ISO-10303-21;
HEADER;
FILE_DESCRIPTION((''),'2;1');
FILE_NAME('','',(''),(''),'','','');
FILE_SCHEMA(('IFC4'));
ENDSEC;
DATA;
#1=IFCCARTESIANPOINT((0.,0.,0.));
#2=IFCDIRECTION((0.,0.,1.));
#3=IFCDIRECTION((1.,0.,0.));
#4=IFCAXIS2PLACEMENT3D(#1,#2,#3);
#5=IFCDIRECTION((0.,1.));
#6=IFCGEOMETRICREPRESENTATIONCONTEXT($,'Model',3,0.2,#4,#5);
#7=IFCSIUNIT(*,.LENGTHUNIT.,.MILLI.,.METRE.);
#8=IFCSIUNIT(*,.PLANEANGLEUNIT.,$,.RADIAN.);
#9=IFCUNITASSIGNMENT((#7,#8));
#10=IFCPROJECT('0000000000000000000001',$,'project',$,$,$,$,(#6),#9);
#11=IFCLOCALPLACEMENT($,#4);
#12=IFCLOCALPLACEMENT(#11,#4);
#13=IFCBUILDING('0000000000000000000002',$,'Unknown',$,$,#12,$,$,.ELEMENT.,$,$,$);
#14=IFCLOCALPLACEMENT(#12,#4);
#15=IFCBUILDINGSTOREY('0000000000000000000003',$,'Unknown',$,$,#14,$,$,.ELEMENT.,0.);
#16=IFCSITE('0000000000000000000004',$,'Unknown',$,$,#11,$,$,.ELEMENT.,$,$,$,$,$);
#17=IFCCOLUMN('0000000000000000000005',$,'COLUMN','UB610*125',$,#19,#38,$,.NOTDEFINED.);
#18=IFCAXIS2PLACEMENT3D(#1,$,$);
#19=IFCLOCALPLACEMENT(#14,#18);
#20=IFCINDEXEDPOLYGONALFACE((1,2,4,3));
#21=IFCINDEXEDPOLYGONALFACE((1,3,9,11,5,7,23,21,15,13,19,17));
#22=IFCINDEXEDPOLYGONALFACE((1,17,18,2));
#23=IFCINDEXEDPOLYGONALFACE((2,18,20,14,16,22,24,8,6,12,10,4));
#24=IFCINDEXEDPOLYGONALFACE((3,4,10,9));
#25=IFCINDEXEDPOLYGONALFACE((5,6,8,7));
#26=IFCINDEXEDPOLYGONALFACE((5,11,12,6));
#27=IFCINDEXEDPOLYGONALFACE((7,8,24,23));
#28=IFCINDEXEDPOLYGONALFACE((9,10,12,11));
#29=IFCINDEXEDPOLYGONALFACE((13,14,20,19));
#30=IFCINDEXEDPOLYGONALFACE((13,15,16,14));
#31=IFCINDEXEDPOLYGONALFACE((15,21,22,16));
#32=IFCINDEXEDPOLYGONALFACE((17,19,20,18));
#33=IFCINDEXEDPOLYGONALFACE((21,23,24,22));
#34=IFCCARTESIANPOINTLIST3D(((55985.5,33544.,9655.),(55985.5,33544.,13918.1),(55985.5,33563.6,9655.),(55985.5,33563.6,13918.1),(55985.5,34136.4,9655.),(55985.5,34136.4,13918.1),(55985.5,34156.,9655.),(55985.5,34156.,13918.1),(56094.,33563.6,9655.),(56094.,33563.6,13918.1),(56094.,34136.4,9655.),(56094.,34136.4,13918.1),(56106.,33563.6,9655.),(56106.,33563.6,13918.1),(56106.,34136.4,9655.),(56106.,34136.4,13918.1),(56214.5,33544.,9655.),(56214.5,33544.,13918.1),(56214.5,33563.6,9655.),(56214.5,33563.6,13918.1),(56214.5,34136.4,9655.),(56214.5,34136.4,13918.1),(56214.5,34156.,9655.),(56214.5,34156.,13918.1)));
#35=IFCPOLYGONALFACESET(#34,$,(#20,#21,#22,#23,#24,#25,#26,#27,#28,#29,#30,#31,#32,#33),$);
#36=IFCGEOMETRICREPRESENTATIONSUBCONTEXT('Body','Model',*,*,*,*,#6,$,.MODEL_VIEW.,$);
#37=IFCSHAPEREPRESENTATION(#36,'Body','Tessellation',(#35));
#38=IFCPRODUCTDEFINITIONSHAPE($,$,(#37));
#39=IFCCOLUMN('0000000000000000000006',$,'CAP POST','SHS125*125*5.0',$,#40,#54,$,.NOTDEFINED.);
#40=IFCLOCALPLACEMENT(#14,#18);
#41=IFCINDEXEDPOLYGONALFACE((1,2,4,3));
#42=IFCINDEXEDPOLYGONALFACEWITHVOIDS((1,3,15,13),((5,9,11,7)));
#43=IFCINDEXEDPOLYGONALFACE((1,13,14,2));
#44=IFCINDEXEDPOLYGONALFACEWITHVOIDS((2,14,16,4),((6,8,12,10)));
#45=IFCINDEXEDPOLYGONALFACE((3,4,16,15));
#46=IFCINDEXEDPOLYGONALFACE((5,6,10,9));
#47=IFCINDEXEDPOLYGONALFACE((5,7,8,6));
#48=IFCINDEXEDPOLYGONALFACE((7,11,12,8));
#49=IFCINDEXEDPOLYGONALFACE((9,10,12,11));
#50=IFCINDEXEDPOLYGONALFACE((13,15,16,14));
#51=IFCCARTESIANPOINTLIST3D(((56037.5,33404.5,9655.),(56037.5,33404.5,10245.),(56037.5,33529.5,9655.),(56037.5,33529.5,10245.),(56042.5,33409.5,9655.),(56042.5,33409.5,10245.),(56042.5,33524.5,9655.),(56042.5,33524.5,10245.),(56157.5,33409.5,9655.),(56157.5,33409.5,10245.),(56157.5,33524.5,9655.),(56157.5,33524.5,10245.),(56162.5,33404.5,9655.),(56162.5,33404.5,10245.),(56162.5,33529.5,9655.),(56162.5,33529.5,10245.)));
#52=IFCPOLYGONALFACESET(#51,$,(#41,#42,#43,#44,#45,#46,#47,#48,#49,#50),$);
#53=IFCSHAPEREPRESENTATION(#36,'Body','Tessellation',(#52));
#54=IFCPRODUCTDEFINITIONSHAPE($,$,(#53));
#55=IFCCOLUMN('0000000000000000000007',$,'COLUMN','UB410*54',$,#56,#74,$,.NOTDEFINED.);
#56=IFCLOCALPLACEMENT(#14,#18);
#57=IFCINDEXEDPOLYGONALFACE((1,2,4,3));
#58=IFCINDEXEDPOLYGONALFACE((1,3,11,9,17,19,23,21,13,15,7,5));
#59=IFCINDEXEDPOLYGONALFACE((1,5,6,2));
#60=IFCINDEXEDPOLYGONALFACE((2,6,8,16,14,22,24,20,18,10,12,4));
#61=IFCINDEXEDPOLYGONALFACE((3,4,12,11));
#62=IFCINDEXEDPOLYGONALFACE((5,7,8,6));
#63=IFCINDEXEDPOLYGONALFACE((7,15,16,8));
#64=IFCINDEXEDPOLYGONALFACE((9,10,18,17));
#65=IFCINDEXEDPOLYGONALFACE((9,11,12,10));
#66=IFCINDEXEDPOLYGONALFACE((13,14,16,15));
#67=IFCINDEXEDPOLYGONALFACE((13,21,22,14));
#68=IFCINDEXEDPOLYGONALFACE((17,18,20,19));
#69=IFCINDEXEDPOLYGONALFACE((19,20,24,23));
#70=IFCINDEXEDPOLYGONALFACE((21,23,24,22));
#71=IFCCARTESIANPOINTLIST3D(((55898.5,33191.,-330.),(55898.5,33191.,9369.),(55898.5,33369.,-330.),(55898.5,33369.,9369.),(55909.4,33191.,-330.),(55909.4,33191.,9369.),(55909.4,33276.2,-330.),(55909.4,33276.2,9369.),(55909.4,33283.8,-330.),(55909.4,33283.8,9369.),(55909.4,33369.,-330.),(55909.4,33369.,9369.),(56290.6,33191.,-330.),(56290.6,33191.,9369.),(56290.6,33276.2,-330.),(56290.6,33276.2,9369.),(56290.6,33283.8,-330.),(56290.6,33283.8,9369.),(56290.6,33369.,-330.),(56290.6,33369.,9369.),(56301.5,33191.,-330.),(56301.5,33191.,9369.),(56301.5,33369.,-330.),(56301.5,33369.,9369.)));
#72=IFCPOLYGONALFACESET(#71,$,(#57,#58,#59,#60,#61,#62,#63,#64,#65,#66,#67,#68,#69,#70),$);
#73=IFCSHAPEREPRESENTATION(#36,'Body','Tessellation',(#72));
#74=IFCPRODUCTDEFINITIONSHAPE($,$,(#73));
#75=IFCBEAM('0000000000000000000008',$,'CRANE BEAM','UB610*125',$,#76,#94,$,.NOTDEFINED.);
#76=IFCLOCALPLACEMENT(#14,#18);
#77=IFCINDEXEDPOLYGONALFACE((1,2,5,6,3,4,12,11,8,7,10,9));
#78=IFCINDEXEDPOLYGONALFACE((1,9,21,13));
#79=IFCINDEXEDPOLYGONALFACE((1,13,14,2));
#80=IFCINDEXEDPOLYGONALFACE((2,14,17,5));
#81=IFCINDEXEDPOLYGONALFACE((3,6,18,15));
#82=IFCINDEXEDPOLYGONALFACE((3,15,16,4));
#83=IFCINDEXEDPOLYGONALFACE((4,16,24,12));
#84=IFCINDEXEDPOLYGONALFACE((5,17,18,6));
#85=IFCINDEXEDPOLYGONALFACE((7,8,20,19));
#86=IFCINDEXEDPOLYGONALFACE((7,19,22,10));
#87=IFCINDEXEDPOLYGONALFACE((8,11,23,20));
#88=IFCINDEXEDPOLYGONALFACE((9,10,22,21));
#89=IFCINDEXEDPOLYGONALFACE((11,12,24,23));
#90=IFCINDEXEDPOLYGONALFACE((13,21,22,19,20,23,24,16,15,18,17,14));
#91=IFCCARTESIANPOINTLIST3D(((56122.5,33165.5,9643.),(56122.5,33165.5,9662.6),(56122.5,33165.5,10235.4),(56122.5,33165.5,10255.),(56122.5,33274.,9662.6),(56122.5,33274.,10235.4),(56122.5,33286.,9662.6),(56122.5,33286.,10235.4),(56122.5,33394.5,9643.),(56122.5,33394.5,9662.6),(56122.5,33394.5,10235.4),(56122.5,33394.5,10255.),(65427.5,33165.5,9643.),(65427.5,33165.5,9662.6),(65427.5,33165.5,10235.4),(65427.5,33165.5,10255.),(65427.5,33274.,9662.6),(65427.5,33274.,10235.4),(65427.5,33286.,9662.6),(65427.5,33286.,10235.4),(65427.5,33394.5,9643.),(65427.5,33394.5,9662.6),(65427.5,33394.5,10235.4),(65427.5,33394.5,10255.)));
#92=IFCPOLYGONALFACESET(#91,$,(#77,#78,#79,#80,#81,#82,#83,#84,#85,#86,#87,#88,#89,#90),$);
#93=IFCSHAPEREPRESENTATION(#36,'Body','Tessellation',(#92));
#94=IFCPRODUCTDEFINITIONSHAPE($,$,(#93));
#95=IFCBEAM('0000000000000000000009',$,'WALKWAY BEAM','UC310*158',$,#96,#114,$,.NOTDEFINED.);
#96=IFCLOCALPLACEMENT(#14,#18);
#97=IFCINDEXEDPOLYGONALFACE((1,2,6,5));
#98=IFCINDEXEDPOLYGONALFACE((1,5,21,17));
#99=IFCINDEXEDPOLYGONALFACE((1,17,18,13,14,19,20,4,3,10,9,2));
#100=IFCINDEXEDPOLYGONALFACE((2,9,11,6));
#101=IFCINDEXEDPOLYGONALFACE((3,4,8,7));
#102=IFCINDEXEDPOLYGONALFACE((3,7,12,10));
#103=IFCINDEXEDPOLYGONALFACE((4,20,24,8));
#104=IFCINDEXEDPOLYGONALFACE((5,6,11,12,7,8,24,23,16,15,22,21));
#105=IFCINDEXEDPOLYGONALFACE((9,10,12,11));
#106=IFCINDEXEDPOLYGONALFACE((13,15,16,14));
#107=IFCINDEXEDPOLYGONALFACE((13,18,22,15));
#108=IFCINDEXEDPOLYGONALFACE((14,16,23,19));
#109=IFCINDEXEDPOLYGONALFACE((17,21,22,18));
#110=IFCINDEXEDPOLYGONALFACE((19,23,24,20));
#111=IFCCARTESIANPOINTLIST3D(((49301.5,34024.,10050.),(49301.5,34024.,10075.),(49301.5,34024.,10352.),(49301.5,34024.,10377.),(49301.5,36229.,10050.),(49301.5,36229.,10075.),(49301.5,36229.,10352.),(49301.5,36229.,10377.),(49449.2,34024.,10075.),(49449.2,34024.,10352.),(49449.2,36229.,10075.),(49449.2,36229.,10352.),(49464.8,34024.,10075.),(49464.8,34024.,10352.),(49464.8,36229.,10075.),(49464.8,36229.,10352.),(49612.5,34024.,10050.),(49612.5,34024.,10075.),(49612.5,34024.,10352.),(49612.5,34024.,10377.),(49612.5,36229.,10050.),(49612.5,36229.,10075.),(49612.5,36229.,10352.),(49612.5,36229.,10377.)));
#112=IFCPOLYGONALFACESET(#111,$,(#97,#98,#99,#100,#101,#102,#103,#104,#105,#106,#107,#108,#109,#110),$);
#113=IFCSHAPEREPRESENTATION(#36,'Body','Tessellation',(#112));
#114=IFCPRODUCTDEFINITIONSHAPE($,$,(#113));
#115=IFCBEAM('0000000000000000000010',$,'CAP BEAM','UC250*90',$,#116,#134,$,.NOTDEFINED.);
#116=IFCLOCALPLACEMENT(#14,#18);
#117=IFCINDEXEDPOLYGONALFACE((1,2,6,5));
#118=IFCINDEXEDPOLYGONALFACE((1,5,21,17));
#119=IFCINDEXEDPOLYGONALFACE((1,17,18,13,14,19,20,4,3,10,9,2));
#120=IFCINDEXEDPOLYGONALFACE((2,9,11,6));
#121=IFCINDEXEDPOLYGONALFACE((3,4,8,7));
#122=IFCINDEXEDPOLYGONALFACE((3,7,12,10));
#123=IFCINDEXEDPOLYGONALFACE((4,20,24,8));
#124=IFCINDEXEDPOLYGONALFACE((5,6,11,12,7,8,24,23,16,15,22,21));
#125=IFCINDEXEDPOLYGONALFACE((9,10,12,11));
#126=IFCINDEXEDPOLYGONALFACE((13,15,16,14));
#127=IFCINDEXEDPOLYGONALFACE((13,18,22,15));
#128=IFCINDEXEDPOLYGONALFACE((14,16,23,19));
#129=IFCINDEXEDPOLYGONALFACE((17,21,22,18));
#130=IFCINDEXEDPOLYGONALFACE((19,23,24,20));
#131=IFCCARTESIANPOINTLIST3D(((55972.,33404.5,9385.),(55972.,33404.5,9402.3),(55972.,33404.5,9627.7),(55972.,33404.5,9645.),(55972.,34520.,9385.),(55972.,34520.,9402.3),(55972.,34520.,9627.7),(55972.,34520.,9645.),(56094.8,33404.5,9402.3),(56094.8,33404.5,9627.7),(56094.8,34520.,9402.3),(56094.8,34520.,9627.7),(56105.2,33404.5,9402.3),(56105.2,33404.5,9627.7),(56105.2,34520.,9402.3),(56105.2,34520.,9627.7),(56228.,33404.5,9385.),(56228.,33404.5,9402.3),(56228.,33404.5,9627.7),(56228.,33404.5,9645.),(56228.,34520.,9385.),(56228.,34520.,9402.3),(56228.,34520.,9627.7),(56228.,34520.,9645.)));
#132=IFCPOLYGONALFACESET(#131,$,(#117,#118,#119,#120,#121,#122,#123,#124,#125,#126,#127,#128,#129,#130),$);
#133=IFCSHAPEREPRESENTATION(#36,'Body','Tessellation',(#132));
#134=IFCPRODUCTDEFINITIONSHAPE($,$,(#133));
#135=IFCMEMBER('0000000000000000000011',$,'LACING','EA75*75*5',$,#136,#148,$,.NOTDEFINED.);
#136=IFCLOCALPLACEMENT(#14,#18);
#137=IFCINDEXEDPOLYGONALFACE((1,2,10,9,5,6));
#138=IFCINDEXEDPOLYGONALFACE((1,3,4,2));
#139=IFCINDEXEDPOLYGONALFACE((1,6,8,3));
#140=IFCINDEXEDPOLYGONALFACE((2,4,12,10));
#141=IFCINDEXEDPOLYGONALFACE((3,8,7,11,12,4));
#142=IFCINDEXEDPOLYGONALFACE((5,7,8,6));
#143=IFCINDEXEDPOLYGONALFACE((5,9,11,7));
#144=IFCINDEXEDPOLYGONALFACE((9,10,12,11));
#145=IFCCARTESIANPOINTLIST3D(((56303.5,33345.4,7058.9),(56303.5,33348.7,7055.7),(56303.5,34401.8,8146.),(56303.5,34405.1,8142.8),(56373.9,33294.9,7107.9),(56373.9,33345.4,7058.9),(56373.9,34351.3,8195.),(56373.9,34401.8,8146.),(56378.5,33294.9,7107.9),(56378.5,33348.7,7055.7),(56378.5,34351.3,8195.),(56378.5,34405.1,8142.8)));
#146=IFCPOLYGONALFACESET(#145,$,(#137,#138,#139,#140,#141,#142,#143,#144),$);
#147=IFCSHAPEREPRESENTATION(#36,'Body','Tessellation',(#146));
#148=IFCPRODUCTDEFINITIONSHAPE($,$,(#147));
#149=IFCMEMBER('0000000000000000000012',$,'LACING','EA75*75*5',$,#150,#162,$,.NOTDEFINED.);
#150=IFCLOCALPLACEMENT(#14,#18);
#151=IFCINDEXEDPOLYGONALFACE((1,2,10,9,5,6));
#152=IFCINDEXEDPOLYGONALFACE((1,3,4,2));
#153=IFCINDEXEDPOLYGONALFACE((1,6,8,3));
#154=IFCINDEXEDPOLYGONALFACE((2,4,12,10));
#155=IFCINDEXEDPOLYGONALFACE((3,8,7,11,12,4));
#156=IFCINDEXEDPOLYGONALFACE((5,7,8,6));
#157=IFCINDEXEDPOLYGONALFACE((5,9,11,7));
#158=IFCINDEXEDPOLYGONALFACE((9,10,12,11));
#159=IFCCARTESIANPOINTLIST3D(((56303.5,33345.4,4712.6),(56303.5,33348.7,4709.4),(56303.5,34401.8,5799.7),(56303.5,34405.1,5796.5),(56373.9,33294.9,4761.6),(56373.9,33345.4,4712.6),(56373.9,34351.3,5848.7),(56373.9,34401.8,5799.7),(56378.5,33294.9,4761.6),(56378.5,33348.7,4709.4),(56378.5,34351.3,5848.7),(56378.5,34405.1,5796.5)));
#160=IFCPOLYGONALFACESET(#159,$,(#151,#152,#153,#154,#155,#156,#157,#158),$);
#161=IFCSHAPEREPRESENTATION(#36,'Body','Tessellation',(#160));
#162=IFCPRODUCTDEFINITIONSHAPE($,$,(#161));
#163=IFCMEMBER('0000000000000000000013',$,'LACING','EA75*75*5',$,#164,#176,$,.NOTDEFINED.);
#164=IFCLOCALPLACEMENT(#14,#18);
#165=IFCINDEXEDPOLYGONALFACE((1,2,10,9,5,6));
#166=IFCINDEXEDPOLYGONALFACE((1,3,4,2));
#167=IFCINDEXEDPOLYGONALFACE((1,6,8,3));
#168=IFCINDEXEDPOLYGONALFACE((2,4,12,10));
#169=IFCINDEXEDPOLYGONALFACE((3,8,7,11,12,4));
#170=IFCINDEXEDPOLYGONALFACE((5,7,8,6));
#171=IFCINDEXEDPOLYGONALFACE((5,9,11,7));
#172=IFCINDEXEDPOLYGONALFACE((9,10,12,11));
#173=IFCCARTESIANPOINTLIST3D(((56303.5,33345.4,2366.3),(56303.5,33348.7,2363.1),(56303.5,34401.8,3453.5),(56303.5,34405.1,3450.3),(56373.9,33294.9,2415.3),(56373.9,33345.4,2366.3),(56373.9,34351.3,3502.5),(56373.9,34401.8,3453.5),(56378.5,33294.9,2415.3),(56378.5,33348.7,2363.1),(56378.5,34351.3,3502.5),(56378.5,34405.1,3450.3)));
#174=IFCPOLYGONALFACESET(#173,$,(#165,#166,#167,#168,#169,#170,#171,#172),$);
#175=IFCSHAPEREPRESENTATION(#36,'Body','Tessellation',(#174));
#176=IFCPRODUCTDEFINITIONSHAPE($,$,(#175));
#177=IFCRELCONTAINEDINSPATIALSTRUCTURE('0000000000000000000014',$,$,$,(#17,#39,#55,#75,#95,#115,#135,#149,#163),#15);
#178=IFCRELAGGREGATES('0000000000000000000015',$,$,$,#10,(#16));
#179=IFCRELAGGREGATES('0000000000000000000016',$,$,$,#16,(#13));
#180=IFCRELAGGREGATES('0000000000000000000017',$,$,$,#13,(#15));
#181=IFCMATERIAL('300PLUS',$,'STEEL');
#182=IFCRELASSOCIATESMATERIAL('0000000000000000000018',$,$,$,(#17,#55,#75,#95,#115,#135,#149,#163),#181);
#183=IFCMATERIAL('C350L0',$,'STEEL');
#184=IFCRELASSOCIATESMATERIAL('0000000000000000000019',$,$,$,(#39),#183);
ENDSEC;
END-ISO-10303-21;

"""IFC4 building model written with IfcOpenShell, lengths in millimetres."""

from ifc_helpers import new_model, si_unit, direction, frame, origin_with_axes, place, context, subcontext, project, spatial, line, indexed_curve, outline, extrude, material, element, save


model = new_model("IFC4")

# Units and contexts
model_context = context("Model", 3, precision=0.2, world=origin_with_axes(), true_north=direction((0.0, 1.0)))
body_context = subcontext(model_context, "Body", "Model", "MODEL_VIEW")
ifc_project = project(units=[si_unit("LENGTHUNIT", "METRE", prefix="MILLI"), si_unit("PLANEANGLEUNIT", "RADIAN")], contexts=[model_context])

# Site, building, storey
site_placement = place(None, origin_with_axes())
site = spatial("IfcSite", under=ifc_project, at=site_placement, Name="Unknown", CompositionType="ELEMENT")
building_placement = place(site_placement, origin_with_axes())
building = spatial("IfcBuilding", under=site, at=building_placement, Name="Unknown", CompositionType="ELEMENT")
storey_placement = place(building_placement, origin_with_axes())
storey = spatial("IfcBuildingStorey", under=building, at=storey_placement, Name="Unknown", CompositionType="ELEMENT", Elevation=0.0)

# Columns
ifc_material_1 = material(Name="300PLUS", Category="STEEL")
column_1_placement = place(storey_placement, frame((56100.0, 33850.0, 9655.0), z_axis=(-1.0, 0.0, 0.0), x_axis=(0.0, 0.0, 1.0)))
element("IfcColumn", 1, at=column_1_placement, inside=storey, material=ifc_material_1, Name="COLUMN", Description="UB610*125", PredefinedType="NOTDEFINED", context=body_context, shape_type="SolidModel", body=[
    extrude(outline(indexed_curve([(-114.5, -306.0), (114.5, -306.0), (114.5, -286.4), (6.0, -286.4), (6.0, 286.4), (114.5, 286.4), (114.5, 306.0), (-114.5, 306.0), (-114.5, 286.4), (-6.0, 286.4), (-6.0, -286.4), (-114.5, -286.4)], segments=[line(1, 2, 3, 4, 5, 6, 7, 8, 9, 10, 11, 12, 1)])), frame((0.0, 0.0, 0.0), z_axis=(-1.0, 0.0, 0.0), x_axis=(0.0, 0.0, 1.0)), (0.0, 0.0, -1.0), 4263.1),
])
ifc_material_2 = material(Name="C350L0", Category="STEEL")
column_2_placement = place(storey_placement, frame((56100.0, 33467.0, 9655.0), z_axis=(-1.0, 0.0, 0.0), x_axis=(0.0, 0.0, 1.0)))
element("IfcColumn", 2, at=column_2_placement, inside=storey, material=ifc_material_2, Name="CAP POST", Description="SHS125*125*5.0", PredefinedType="NOTDEFINED", context=body_context, shape_type="SolidModel", body=[
    extrude(outline(indexed_curve([(-62.5, -62.5), (62.5, -62.5), (62.5, 62.5), (-62.5, 62.5)], segments=[line(1, 2, 3, 4, 1)]), holes=[indexed_curve([(-57.5, -57.5), (-57.5, 57.5), (57.5, 57.5), (57.5, -57.5)], segments=[line(1, 2, 3, 4, 1)])]), frame((0.0, 0.0, 0.0), z_axis=(-1.0, 0.0, 0.0), x_axis=(0.0, 0.0, 1.0)), (0.0, 0.0, -1.0), 590.0),
])
column_3_placement = place(storey_placement, frame((56100.0, 33280.0, -330.0), z_axis=(0.0, -1.0, 0.0), x_axis=(0.0, 0.0, 1.0)))
element("IfcColumn", 3, at=column_3_placement, inside=storey, material=ifc_material_1, Name="COLUMN", Description="UB410*54", PredefinedType="NOTDEFINED", context=body_context, shape_type="SolidModel", body=[
    extrude(outline(indexed_curve([(-89.0, -201.5), (89.0, -201.5), (89.0, -190.6), (3.8, -190.6), (3.8, 190.6), (89.0, 190.6), (89.0, 201.5), (-89.0, 201.5), (-89.0, 190.6), (-3.8, 190.6), (-3.8, -190.6), (-89.0, -190.6)], segments=[line(1, 2, 3, 4, 5, 6, 7, 8, 9, 10, 11, 12, 1)])), frame((0.0, 0.0, 0.0), z_axis=(-1.0, 0.0, 0.0), x_axis=(0.0, 0.0, 1.0)), (0.0, 0.0, -1.0), 9699.0),
])

# Beams
beam_1_placement = place(storey_placement, frame((56122.5, 33280.0, 9949.0), z_axis=(0.0, -1.0, 0.0), x_axis=(1.0, 0.0, 0.0)))
element("IfcBeam", 4, at=beam_1_placement, inside=storey, material=ifc_material_1, Name="CRANE BEAM", Description="UB610*125", PredefinedType="NOTDEFINED", context=body_context, shape_type="SolidModel", body=[
    extrude(outline(indexed_curve([(-114.5, -306.0), (114.5, -306.0), (114.5, -286.4), (6.0, -286.4), (6.0, 286.4), (114.5, 286.4), (114.5, 306.0), (-114.5, 306.0), (-114.5, 286.4), (-6.0, 286.4), (-6.0, -286.4), (-114.5, -286.4)], segments=[line(1, 2, 3, 4, 5, 6, 7, 8, 9, 10, 11, 12, 1)])), frame((0.0, 0.0, 0.0), z_axis=(-1.0, 0.0, 0.0), x_axis=(0.0, 0.0, 1.0)), (0.0, 0.0, -1.0), 9305.0),
])
beam_2_placement = place(storey_placement, frame((49457.0, 34024.0, 10213.5), z_axis=(1.0, 0.0, 0.0), x_axis=(0.0, 1.0, 0.0)))
element("IfcBeam", 5, at=beam_2_placement, inside=storey, material=ifc_material_1, Name="WALKWAY BEAM", Description="UC310*158", PredefinedType="NOTDEFINED", context=body_context, shape_type="SolidModel", body=[
    extrude(outline(indexed_curve([(-155.5, -163.5), (155.5, -163.5), (155.5, -138.5), (7.8, -138.5), (7.8, 138.5), (155.5, 138.5), (155.5, 163.5), (-155.5, 163.5), (-155.5, 138.5), (-7.8, 138.5), (-7.8, -138.5), (-155.5, -138.5)], segments=[line(1, 2, 3, 4, 5, 6, 7, 8, 9, 10, 11, 12, 1)])), frame((0.0, 0.0, 0.0), z_axis=(-1.0, 0.0, 0.0), x_axis=(0.0, 0.0, 1.0)), (0.0, 0.0, -1.0), 2205.0),
])
beam_3_placement = place(storey_placement, frame((56100.0, 33404.5, 9515.0), z_axis=(1.0, 0.0, 0.0), x_axis=(0.0, 1.0, 0.0)))
element("IfcBeam", 6, at=beam_3_placement, inside=storey, material=ifc_material_1, Name="CAP BEAM", Description="UC250*90", PredefinedType="NOTDEFINED", context=body_context, shape_type="SolidModel", body=[
    extrude(outline(indexed_curve([(-128.0, -130.0), (128.0, -130.0), (128.0, -112.7), (5.2, -112.7), (5.2, 112.7), (128.0, 112.7), (128.0, 130.0), (-128.0, 130.0), (-128.0, 112.7), (-5.2, 112.7), (-5.2, -112.7), (-128.0, -112.7)], segments=[line(1, 2, 3, 4, 5, 6, 7, 8, 9, 10, 11, 12, 1)])), frame((0.0, 0.0, 0.0), z_axis=(-1.0, 0.0, 0.0), x_axis=(0.0, 0.0, 1.0)), (0.0, 0.0, -1.0), 1115.5),
])

# Members
for number, where, z_axis, x_axis, name in (
    (7, (56341.0, 33321.8, 7081.8), (0.0, -0.717161, 0.696908), (0.0, 0.696908, 0.717161), "LACING"),
    (8, (56341.0, 33321.8, 4735.5), (0.0, -0.717161, 0.696908), (0.0, 0.696908, 0.717161), "LACING"),
):
    element("IfcMember", number, at=place(storey_placement, frame(where, z_axis=z_axis, x_axis=x_axis)), inside=storey, material=ifc_material_1, Name=name, Description="EA75*75*5", PredefinedType="NOTDEFINED", context=body_context, shape_type="SolidModel", body=[
        extrude(outline(indexed_curve([(-37.5, -37.5), (37.5, -37.5), (37.5, -32.9), (-32.9, -32.9), (-32.9, 37.5), (-37.5, 37.5)], segments=[line(1, 2, 3, 4, 5, 6, 1)])), frame((0.0, 0.0, 0.0), z_axis=(-1.0, 0.0, 0.0), x_axis=(0.0, 0.0, 1.0)), (0.0, 0.0, -1.0), 1515.8),
    ])
member_1_placement = place(storey_placement, frame((56341.0, 33321.8, 2389.2), z_axis=(0.0, -0.717193, 0.696875), x_axis=(0.0, 0.696875, 0.717193)))
element("IfcMember", 9, at=member_1_placement, inside=storey, material=ifc_material_1, Name="LACING", Description="EA75*75*5", PredefinedType="NOTDEFINED", context=body_context, shape_type="SolidModel", body=[
    extrude(outline(indexed_curve([(-37.5, -37.5), (37.5, -37.5), (37.5, -32.9), (-32.9, -32.9), (-32.9, 37.5), (-37.5, 37.5)], segments=[line(1, 2, 3, 4, 5, 6, 1)])), frame((0.0, 0.0, 0.0), z_axis=(-1.0, 0.0, 0.0), x_axis=(0.0, 0.0, 1.0)), (0.0, 0.0, -1.0), 1515.9),
])

save(model, "model.ifc")
